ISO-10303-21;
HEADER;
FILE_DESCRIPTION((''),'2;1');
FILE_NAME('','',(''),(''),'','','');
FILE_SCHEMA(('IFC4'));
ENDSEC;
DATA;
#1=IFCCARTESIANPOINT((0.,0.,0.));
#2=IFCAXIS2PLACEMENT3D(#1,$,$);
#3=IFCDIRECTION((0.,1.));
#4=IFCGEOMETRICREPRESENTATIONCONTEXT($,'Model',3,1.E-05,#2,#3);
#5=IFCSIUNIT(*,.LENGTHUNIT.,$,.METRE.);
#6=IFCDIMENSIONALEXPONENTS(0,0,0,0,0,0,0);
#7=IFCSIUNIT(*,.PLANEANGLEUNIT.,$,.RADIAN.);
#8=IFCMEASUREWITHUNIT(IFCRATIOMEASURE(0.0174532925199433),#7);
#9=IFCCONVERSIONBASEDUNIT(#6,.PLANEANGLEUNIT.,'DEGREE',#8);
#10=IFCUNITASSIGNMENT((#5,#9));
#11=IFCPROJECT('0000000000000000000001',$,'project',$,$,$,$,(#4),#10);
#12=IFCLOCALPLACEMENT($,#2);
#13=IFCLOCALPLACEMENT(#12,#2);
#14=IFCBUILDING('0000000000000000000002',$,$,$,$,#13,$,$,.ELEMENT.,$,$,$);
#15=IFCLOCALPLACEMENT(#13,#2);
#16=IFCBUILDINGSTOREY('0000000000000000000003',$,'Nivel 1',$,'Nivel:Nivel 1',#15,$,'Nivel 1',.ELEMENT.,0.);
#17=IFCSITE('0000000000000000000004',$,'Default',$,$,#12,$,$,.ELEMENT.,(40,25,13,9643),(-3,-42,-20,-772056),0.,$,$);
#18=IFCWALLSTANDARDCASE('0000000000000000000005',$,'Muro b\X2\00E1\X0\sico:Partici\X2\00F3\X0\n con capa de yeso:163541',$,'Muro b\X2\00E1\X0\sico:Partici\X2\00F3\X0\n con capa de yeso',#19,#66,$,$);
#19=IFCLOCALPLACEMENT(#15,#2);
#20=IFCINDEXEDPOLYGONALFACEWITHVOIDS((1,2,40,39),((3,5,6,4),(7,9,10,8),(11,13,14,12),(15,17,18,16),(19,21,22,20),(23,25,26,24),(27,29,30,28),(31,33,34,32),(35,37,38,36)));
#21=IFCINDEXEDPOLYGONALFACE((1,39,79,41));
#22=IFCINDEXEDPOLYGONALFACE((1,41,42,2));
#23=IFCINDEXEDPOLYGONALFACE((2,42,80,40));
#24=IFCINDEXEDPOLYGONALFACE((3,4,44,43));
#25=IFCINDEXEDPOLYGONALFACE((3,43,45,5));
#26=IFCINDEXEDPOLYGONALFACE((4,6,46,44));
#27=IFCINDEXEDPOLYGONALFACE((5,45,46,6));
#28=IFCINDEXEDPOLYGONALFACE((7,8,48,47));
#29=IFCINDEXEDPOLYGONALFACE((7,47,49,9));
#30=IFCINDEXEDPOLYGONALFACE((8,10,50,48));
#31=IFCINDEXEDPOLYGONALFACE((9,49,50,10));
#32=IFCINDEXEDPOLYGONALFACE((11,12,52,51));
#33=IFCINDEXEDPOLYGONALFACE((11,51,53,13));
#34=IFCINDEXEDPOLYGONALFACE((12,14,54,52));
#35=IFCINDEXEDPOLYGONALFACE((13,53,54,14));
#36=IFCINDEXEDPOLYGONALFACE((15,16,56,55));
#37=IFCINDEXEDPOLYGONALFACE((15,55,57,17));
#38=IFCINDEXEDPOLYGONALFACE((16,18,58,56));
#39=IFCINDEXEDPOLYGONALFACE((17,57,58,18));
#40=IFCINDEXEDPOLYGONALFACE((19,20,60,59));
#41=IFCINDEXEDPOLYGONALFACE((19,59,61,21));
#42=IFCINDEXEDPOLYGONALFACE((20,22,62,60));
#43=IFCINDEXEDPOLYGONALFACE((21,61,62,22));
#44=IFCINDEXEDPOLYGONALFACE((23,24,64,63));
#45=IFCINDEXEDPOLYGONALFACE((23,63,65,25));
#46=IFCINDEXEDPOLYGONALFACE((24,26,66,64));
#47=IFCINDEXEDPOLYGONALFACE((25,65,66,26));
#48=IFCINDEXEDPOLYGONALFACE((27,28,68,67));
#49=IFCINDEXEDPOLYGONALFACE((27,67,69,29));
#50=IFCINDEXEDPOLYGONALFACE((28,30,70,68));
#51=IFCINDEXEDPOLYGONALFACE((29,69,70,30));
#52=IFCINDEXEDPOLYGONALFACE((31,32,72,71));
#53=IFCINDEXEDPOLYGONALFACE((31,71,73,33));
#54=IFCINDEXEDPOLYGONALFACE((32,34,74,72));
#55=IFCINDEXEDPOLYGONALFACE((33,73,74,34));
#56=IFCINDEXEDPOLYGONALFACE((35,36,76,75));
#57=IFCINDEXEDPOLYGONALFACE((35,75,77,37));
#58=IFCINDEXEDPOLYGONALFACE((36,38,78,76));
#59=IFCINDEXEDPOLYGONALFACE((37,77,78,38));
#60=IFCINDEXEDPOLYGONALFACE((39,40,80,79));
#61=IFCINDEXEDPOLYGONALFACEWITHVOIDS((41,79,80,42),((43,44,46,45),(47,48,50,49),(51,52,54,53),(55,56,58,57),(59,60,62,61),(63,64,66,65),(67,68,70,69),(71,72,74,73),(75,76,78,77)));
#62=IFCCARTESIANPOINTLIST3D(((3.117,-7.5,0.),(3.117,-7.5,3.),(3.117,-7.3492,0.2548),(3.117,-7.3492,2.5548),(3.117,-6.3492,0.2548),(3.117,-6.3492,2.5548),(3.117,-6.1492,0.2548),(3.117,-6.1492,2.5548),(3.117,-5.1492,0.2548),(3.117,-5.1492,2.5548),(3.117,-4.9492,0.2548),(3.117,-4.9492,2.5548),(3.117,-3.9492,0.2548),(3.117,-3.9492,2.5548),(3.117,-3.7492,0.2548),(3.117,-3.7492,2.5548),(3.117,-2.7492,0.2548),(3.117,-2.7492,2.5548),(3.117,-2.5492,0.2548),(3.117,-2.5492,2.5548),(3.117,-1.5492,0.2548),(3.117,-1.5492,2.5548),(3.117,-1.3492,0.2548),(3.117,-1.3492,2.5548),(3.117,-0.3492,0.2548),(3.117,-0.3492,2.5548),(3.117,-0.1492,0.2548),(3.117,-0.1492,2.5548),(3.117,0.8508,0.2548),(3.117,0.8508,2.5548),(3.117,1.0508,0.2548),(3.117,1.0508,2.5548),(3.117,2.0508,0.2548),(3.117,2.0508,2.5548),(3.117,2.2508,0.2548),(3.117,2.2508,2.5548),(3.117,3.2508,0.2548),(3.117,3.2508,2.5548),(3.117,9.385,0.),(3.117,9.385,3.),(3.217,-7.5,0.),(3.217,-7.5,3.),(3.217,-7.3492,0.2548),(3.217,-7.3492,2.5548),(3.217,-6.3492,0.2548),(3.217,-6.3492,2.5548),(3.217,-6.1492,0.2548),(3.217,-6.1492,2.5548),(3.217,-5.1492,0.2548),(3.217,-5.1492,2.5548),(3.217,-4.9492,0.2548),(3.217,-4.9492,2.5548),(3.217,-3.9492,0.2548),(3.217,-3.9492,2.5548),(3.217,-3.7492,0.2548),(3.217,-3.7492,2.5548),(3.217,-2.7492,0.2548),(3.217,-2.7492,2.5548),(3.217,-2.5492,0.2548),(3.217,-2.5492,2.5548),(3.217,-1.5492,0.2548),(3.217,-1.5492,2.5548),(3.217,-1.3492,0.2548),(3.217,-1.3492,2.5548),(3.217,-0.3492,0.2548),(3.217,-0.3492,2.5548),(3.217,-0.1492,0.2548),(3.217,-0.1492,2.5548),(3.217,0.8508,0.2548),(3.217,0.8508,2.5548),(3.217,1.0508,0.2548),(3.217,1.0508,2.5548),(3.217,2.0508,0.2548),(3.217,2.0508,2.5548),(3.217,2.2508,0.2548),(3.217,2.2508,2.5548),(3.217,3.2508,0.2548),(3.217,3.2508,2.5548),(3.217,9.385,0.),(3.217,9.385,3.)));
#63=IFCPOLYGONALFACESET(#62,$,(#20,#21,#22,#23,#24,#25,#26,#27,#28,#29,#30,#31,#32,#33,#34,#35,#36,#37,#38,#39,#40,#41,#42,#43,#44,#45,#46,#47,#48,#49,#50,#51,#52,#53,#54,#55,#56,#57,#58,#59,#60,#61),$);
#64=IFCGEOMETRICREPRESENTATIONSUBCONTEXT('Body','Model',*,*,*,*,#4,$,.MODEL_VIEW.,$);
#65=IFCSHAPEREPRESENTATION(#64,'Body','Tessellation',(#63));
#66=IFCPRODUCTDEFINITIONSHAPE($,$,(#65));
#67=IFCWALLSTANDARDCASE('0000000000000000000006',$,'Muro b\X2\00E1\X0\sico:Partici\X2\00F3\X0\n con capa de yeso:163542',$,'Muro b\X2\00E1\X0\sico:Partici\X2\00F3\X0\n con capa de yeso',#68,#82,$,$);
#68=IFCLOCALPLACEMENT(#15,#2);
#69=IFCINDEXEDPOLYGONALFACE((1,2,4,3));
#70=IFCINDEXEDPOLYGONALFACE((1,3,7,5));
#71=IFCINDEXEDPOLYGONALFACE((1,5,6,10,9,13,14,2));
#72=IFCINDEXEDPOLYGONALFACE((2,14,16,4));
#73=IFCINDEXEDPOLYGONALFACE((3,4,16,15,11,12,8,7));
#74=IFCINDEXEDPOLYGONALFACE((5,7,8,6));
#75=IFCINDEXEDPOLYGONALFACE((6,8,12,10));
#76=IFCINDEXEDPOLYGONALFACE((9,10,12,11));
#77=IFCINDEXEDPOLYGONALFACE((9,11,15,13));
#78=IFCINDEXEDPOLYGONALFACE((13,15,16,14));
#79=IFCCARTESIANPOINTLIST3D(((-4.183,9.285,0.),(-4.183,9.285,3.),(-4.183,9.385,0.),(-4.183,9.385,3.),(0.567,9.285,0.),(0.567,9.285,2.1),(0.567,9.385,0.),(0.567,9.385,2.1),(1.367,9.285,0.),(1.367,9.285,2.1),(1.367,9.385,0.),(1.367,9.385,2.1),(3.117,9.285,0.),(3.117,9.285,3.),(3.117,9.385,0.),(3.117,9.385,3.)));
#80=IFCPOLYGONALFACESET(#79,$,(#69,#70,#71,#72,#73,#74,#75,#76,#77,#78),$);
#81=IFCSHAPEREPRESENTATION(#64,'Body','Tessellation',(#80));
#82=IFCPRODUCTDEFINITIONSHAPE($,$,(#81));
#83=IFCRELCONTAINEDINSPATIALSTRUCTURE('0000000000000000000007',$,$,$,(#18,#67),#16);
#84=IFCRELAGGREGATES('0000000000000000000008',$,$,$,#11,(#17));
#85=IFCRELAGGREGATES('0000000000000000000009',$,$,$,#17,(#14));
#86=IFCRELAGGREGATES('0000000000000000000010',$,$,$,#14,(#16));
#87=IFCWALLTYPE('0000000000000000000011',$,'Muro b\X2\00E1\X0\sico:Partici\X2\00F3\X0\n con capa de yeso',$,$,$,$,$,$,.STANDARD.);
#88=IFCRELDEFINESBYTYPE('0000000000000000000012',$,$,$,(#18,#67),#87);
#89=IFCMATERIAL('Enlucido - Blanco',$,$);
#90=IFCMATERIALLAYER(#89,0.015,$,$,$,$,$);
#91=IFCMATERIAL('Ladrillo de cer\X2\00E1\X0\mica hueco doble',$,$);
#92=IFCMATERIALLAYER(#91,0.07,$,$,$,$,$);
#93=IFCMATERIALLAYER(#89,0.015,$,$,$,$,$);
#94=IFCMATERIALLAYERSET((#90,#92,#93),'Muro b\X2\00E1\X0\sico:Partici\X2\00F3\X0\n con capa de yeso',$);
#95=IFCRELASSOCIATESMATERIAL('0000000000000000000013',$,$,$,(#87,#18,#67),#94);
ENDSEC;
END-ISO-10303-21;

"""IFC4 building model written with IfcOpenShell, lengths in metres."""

from ifc_helpers import new_model, entity, si_unit, converted_unit, direction, frame, frame_2d, origin, place, context, subcontext, project, spatial, rectangle, extrude, material, layer, layer_set, layer_usage, type_object, element, save


model = new_model("IFC4")

# Units and contexts
model_context = context("Model", 3, precision=1e-05, world=origin(), true_north=direction((0.0, 1.0)))
body_context = subcontext(model_context, "Body", "Model", "MODEL_VIEW")
ifc_project = project(units=[si_unit("LENGTHUNIT", "METRE"), converted_unit("PLANEANGLEUNIT", "DEGREE", entity("IfcRatioMeasure", 0.0174532925199433), si_unit("PLANEANGLEUNIT", "RADIAN"), dimensions=[0, 0, 0, 0, 0, 0, 0])], contexts=[model_context])

# Site, building, storey
site_placement = place(None, origin())
site = spatial("IfcSite", under=ifc_project, at=site_placement, Name="Default", CompositionType="ELEMENT", RefLatitude=(40, 25, 13, 9643), RefLongitude=(-3, -42, -20, -772056), RefElevation=0.0)
building_placement = place(site_placement, origin())
building = spatial("IfcBuilding", under=site, at=building_placement, CompositionType="ELEMENT")
storey_placement = place(building_placement, origin())
storey = spatial("IfcBuildingStorey", under=building, at=storey_placement, Name="Nivel 1", ObjectType="Nivel:Nivel 1", LongName="Nivel 1", CompositionType="ELEMENT", Elevation=0.0)

# Wall, openings
ifc_material_1 = material(Name="Enlucido - Blanco")
ifc_layer_1 = layer(ifc_material_1, 0.015)
ifc_material_2 = material(Name="Ladrillo de cerámica hueco doble")
ifc_layer_2 = layer(ifc_material_2, 0.07)
ifc_layer_3 = layer(ifc_material_1, 0.015)
ifc_layer_set_1 = layer_set([ifc_layer_1, ifc_layer_2, ifc_layer_3], Name="Muro básico:Partición con capa de yeso")
ifc_layer_usage_1 = layer_usage(ifc_layer_set_1, "AXIS2", "NEGATIVE", 0.05)
wall_type = type_object("IfcWallType", Name="Muro básico:Partición con capa de yeso", PredefinedType="STANDARD", material=ifc_layer_set_1)
wall_1_placement = place(storey_placement, frame((3.167, 9.385, 0.0), z_axis=(0.0, 0.0, 1.0), x_axis=(0.0, -1.0, 0.0)))
wall_1 = element("IfcWallStandardCase", 1, at=wall_1_placement, inside=storey, type_object=wall_type, material=ifc_layer_usage_1, Name="Muro básico:Partición con capa de yeso:163541", ObjectType="Muro básico:Partición con capa de yeso", context=body_context, shape_type="SweptSolid", body=[
    extrude(rectangle(XDim=16.885, YDim=0.1, at=frame_2d((8.4425, 0.0), x_axis=(-1.0, 0.0))), origin(), (0.0, 0.0, 1.0), 3.0),
])
opening_1_placement = place(wall_1_placement, frame((13.3342, -0.05, 0.2548)))
element("IfcOpeningElement", 2, at=opening_1_placement, cuts=wall_1, ObjectType="Opening", context=body_context, shape_type="SweptSolid", body=[
    extrude(rectangle(XDim=2.3, YDim=1.0, at=frame_2d((1.15, 0.5), x_axis=(1.0, 0.0))), frame((0.0, 0.0, 0.0), z_axis=(0.0, 1.0, 0.0), x_axis=(0.0, 0.0, 1.0)), (0.0, 0.0, 1.0), 0.1),
])
opening_2_placement = place(wall_1_placement, frame((14.5342, -0.05, 0.2548)))
element("IfcOpeningElement", 3, at=opening_2_placement, cuts=wall_1, ObjectType="Opening", context=body_context, shape_type="SweptSolid", body=[
    extrude(rectangle(XDim=2.3, YDim=1.0, at=frame_2d((1.15, 0.5), x_axis=(1.0, 0.0))), frame((0.0, 0.0, 0.0), z_axis=(0.0, 1.0, 0.0), x_axis=(0.0, 0.0, 1.0)), (0.0, 0.0, 1.0), 0.1),
])
opening_3_placement = place(wall_1_placement, frame((15.7342, -0.05, 0.2548)))
element("IfcOpeningElement", 4, at=opening_3_placement, cuts=wall_1, ObjectType="Opening", context=body_context, shape_type="SweptSolid", body=[
    extrude(rectangle(XDim=2.3, YDim=1.0, at=frame_2d((1.15, 0.5), x_axis=(1.0, 0.0))), frame((0.0, 0.0, 0.0), z_axis=(0.0, 1.0, 0.0), x_axis=(0.0, 0.0, 1.0)), (0.0, 0.0, 1.0), 0.1),
])
opening_4_placement = place(wall_1_placement, frame((9.7342, -0.05, 0.2548)))
element("IfcOpeningElement", 5, at=opening_4_placement, cuts=wall_1, ObjectType="Opening", context=body_context, shape_type="SweptSolid", body=[
    extrude(rectangle(XDim=2.3, YDim=1.0, at=frame_2d((1.15, 0.5), x_axis=(1.0, 0.0))), frame((0.0, 0.0, 0.0), z_axis=(0.0, 1.0, 0.0), x_axis=(0.0, 0.0, 1.0)), (0.0, 0.0, 1.0), 0.1),
])
opening_5_placement = place(wall_1_placement, frame((8.5342, -0.05, 0.2548)))
element("IfcOpeningElement", 6, at=opening_5_placement, cuts=wall_1, ObjectType="Opening", context=body_context, shape_type="SweptSolid", body=[
    extrude(rectangle(XDim=2.3, YDim=1.0, at=frame_2d((1.15, 0.5), x_axis=(1.0, 0.0))), frame((0.0, 0.0, 0.0), z_axis=(0.0, 1.0, 0.0), x_axis=(0.0, 0.0, 1.0)), (0.0, 0.0, 1.0), 0.1),
])
opening_6_placement = place(wall_1_placement, frame((7.3342, -0.05, 0.2548)))
element("IfcOpeningElement", 7, at=opening_6_placement, cuts=wall_1, ObjectType="Opening", context=body_context, shape_type="SweptSolid", body=[
    extrude(rectangle(XDim=2.3, YDim=1.0, at=frame_2d((1.15, 0.5), x_axis=(1.0, 0.0))), frame((0.0, 0.0, 0.0), z_axis=(0.0, 1.0, 0.0), x_axis=(0.0, 0.0, 1.0)), (0.0, 0.0, 1.0), 0.1),
])
opening_7_placement = place(wall_1_placement, frame((10.9342, -0.05, 0.2548)))
element("IfcOpeningElement", 8, at=opening_7_placement, cuts=wall_1, ObjectType="Opening", context=body_context, shape_type="SweptSolid", body=[
    extrude(rectangle(XDim=2.3, YDim=1.0, at=frame_2d((1.15, 0.5), x_axis=(1.0, 0.0))), frame((0.0, 0.0, 0.0), z_axis=(0.0, 1.0, 0.0), x_axis=(0.0, 0.0, 1.0)), (0.0, 0.0, 1.0), 0.1),
])
opening_8_placement = place(wall_1_placement, frame((12.1342, -0.05, 0.2548)))
element("IfcOpeningElement", 9, at=opening_8_placement, cuts=wall_1, ObjectType="Opening", context=body_context, shape_type="SweptSolid", body=[
    extrude(rectangle(XDim=2.3, YDim=1.0, at=frame_2d((1.15, 0.5), x_axis=(1.0, 0.0))), frame((0.0, 0.0, 0.0), z_axis=(0.0, 1.0, 0.0), x_axis=(0.0, 0.0, 1.0)), (0.0, 0.0, 1.0), 0.1),
])
opening_9_placement = place(wall_1_placement, frame((6.1342, -0.05, 0.2548)))
element("IfcOpeningElement", 10, at=opening_9_placement, cuts=wall_1, ObjectType="Opening", context=body_context, shape_type="SweptSolid", body=[
    extrude(rectangle(XDim=2.3, YDim=1.0, at=frame_2d((1.15, 0.5), x_axis=(1.0, 0.0))), frame((0.0, 0.0, 0.0), z_axis=(0.0, 1.0, 0.0), x_axis=(0.0, 0.0, 1.0)), (0.0, 0.0, 1.0), 0.1),
])

# Wall, opening
ifc_layer_usage_2 = layer_usage(ifc_layer_set_1, "AXIS2", "NEGATIVE", 0.05)
wall_2_placement = place(storey_placement, frame((-4.183, 9.335, 0.0)))
wall_2 = element("IfcWallStandardCase", 11, at=wall_2_placement, inside=storey, type_object=wall_type, material=ifc_layer_usage_2, Name="Muro básico:Partición con capa de yeso:163542", ObjectType="Muro básico:Partición con capa de yeso", context=body_context, shape_type="SweptSolid", body=[
    extrude(rectangle(XDim=7.3, YDim=0.1, at=frame_2d((3.65, 0.0), x_axis=(-1.0, 0.0))), origin(), (0.0, 0.0, 1.0), 3.0),
])
opening_10_placement = place(wall_2_placement, frame((5.55, 0.05, 0.0)))
element("IfcOpeningElement", 12, at=opening_10_placement, cuts=wall_2, ObjectType="Opening", context=body_context, shape_type="SweptSolid", body=[
    extrude(rectangle(XDim=2.1, YDim=0.8, at=frame_2d((1.05, 0.4), x_axis=(1.0, 0.0))), frame((0.0, 0.0, 0.0), z_axis=(0.0, -1.0, 0.0), x_axis=(0.0, 0.0, 1.0)), (0.0, 0.0, 1.0), 0.1),
])

save(model, "model.ifc")
